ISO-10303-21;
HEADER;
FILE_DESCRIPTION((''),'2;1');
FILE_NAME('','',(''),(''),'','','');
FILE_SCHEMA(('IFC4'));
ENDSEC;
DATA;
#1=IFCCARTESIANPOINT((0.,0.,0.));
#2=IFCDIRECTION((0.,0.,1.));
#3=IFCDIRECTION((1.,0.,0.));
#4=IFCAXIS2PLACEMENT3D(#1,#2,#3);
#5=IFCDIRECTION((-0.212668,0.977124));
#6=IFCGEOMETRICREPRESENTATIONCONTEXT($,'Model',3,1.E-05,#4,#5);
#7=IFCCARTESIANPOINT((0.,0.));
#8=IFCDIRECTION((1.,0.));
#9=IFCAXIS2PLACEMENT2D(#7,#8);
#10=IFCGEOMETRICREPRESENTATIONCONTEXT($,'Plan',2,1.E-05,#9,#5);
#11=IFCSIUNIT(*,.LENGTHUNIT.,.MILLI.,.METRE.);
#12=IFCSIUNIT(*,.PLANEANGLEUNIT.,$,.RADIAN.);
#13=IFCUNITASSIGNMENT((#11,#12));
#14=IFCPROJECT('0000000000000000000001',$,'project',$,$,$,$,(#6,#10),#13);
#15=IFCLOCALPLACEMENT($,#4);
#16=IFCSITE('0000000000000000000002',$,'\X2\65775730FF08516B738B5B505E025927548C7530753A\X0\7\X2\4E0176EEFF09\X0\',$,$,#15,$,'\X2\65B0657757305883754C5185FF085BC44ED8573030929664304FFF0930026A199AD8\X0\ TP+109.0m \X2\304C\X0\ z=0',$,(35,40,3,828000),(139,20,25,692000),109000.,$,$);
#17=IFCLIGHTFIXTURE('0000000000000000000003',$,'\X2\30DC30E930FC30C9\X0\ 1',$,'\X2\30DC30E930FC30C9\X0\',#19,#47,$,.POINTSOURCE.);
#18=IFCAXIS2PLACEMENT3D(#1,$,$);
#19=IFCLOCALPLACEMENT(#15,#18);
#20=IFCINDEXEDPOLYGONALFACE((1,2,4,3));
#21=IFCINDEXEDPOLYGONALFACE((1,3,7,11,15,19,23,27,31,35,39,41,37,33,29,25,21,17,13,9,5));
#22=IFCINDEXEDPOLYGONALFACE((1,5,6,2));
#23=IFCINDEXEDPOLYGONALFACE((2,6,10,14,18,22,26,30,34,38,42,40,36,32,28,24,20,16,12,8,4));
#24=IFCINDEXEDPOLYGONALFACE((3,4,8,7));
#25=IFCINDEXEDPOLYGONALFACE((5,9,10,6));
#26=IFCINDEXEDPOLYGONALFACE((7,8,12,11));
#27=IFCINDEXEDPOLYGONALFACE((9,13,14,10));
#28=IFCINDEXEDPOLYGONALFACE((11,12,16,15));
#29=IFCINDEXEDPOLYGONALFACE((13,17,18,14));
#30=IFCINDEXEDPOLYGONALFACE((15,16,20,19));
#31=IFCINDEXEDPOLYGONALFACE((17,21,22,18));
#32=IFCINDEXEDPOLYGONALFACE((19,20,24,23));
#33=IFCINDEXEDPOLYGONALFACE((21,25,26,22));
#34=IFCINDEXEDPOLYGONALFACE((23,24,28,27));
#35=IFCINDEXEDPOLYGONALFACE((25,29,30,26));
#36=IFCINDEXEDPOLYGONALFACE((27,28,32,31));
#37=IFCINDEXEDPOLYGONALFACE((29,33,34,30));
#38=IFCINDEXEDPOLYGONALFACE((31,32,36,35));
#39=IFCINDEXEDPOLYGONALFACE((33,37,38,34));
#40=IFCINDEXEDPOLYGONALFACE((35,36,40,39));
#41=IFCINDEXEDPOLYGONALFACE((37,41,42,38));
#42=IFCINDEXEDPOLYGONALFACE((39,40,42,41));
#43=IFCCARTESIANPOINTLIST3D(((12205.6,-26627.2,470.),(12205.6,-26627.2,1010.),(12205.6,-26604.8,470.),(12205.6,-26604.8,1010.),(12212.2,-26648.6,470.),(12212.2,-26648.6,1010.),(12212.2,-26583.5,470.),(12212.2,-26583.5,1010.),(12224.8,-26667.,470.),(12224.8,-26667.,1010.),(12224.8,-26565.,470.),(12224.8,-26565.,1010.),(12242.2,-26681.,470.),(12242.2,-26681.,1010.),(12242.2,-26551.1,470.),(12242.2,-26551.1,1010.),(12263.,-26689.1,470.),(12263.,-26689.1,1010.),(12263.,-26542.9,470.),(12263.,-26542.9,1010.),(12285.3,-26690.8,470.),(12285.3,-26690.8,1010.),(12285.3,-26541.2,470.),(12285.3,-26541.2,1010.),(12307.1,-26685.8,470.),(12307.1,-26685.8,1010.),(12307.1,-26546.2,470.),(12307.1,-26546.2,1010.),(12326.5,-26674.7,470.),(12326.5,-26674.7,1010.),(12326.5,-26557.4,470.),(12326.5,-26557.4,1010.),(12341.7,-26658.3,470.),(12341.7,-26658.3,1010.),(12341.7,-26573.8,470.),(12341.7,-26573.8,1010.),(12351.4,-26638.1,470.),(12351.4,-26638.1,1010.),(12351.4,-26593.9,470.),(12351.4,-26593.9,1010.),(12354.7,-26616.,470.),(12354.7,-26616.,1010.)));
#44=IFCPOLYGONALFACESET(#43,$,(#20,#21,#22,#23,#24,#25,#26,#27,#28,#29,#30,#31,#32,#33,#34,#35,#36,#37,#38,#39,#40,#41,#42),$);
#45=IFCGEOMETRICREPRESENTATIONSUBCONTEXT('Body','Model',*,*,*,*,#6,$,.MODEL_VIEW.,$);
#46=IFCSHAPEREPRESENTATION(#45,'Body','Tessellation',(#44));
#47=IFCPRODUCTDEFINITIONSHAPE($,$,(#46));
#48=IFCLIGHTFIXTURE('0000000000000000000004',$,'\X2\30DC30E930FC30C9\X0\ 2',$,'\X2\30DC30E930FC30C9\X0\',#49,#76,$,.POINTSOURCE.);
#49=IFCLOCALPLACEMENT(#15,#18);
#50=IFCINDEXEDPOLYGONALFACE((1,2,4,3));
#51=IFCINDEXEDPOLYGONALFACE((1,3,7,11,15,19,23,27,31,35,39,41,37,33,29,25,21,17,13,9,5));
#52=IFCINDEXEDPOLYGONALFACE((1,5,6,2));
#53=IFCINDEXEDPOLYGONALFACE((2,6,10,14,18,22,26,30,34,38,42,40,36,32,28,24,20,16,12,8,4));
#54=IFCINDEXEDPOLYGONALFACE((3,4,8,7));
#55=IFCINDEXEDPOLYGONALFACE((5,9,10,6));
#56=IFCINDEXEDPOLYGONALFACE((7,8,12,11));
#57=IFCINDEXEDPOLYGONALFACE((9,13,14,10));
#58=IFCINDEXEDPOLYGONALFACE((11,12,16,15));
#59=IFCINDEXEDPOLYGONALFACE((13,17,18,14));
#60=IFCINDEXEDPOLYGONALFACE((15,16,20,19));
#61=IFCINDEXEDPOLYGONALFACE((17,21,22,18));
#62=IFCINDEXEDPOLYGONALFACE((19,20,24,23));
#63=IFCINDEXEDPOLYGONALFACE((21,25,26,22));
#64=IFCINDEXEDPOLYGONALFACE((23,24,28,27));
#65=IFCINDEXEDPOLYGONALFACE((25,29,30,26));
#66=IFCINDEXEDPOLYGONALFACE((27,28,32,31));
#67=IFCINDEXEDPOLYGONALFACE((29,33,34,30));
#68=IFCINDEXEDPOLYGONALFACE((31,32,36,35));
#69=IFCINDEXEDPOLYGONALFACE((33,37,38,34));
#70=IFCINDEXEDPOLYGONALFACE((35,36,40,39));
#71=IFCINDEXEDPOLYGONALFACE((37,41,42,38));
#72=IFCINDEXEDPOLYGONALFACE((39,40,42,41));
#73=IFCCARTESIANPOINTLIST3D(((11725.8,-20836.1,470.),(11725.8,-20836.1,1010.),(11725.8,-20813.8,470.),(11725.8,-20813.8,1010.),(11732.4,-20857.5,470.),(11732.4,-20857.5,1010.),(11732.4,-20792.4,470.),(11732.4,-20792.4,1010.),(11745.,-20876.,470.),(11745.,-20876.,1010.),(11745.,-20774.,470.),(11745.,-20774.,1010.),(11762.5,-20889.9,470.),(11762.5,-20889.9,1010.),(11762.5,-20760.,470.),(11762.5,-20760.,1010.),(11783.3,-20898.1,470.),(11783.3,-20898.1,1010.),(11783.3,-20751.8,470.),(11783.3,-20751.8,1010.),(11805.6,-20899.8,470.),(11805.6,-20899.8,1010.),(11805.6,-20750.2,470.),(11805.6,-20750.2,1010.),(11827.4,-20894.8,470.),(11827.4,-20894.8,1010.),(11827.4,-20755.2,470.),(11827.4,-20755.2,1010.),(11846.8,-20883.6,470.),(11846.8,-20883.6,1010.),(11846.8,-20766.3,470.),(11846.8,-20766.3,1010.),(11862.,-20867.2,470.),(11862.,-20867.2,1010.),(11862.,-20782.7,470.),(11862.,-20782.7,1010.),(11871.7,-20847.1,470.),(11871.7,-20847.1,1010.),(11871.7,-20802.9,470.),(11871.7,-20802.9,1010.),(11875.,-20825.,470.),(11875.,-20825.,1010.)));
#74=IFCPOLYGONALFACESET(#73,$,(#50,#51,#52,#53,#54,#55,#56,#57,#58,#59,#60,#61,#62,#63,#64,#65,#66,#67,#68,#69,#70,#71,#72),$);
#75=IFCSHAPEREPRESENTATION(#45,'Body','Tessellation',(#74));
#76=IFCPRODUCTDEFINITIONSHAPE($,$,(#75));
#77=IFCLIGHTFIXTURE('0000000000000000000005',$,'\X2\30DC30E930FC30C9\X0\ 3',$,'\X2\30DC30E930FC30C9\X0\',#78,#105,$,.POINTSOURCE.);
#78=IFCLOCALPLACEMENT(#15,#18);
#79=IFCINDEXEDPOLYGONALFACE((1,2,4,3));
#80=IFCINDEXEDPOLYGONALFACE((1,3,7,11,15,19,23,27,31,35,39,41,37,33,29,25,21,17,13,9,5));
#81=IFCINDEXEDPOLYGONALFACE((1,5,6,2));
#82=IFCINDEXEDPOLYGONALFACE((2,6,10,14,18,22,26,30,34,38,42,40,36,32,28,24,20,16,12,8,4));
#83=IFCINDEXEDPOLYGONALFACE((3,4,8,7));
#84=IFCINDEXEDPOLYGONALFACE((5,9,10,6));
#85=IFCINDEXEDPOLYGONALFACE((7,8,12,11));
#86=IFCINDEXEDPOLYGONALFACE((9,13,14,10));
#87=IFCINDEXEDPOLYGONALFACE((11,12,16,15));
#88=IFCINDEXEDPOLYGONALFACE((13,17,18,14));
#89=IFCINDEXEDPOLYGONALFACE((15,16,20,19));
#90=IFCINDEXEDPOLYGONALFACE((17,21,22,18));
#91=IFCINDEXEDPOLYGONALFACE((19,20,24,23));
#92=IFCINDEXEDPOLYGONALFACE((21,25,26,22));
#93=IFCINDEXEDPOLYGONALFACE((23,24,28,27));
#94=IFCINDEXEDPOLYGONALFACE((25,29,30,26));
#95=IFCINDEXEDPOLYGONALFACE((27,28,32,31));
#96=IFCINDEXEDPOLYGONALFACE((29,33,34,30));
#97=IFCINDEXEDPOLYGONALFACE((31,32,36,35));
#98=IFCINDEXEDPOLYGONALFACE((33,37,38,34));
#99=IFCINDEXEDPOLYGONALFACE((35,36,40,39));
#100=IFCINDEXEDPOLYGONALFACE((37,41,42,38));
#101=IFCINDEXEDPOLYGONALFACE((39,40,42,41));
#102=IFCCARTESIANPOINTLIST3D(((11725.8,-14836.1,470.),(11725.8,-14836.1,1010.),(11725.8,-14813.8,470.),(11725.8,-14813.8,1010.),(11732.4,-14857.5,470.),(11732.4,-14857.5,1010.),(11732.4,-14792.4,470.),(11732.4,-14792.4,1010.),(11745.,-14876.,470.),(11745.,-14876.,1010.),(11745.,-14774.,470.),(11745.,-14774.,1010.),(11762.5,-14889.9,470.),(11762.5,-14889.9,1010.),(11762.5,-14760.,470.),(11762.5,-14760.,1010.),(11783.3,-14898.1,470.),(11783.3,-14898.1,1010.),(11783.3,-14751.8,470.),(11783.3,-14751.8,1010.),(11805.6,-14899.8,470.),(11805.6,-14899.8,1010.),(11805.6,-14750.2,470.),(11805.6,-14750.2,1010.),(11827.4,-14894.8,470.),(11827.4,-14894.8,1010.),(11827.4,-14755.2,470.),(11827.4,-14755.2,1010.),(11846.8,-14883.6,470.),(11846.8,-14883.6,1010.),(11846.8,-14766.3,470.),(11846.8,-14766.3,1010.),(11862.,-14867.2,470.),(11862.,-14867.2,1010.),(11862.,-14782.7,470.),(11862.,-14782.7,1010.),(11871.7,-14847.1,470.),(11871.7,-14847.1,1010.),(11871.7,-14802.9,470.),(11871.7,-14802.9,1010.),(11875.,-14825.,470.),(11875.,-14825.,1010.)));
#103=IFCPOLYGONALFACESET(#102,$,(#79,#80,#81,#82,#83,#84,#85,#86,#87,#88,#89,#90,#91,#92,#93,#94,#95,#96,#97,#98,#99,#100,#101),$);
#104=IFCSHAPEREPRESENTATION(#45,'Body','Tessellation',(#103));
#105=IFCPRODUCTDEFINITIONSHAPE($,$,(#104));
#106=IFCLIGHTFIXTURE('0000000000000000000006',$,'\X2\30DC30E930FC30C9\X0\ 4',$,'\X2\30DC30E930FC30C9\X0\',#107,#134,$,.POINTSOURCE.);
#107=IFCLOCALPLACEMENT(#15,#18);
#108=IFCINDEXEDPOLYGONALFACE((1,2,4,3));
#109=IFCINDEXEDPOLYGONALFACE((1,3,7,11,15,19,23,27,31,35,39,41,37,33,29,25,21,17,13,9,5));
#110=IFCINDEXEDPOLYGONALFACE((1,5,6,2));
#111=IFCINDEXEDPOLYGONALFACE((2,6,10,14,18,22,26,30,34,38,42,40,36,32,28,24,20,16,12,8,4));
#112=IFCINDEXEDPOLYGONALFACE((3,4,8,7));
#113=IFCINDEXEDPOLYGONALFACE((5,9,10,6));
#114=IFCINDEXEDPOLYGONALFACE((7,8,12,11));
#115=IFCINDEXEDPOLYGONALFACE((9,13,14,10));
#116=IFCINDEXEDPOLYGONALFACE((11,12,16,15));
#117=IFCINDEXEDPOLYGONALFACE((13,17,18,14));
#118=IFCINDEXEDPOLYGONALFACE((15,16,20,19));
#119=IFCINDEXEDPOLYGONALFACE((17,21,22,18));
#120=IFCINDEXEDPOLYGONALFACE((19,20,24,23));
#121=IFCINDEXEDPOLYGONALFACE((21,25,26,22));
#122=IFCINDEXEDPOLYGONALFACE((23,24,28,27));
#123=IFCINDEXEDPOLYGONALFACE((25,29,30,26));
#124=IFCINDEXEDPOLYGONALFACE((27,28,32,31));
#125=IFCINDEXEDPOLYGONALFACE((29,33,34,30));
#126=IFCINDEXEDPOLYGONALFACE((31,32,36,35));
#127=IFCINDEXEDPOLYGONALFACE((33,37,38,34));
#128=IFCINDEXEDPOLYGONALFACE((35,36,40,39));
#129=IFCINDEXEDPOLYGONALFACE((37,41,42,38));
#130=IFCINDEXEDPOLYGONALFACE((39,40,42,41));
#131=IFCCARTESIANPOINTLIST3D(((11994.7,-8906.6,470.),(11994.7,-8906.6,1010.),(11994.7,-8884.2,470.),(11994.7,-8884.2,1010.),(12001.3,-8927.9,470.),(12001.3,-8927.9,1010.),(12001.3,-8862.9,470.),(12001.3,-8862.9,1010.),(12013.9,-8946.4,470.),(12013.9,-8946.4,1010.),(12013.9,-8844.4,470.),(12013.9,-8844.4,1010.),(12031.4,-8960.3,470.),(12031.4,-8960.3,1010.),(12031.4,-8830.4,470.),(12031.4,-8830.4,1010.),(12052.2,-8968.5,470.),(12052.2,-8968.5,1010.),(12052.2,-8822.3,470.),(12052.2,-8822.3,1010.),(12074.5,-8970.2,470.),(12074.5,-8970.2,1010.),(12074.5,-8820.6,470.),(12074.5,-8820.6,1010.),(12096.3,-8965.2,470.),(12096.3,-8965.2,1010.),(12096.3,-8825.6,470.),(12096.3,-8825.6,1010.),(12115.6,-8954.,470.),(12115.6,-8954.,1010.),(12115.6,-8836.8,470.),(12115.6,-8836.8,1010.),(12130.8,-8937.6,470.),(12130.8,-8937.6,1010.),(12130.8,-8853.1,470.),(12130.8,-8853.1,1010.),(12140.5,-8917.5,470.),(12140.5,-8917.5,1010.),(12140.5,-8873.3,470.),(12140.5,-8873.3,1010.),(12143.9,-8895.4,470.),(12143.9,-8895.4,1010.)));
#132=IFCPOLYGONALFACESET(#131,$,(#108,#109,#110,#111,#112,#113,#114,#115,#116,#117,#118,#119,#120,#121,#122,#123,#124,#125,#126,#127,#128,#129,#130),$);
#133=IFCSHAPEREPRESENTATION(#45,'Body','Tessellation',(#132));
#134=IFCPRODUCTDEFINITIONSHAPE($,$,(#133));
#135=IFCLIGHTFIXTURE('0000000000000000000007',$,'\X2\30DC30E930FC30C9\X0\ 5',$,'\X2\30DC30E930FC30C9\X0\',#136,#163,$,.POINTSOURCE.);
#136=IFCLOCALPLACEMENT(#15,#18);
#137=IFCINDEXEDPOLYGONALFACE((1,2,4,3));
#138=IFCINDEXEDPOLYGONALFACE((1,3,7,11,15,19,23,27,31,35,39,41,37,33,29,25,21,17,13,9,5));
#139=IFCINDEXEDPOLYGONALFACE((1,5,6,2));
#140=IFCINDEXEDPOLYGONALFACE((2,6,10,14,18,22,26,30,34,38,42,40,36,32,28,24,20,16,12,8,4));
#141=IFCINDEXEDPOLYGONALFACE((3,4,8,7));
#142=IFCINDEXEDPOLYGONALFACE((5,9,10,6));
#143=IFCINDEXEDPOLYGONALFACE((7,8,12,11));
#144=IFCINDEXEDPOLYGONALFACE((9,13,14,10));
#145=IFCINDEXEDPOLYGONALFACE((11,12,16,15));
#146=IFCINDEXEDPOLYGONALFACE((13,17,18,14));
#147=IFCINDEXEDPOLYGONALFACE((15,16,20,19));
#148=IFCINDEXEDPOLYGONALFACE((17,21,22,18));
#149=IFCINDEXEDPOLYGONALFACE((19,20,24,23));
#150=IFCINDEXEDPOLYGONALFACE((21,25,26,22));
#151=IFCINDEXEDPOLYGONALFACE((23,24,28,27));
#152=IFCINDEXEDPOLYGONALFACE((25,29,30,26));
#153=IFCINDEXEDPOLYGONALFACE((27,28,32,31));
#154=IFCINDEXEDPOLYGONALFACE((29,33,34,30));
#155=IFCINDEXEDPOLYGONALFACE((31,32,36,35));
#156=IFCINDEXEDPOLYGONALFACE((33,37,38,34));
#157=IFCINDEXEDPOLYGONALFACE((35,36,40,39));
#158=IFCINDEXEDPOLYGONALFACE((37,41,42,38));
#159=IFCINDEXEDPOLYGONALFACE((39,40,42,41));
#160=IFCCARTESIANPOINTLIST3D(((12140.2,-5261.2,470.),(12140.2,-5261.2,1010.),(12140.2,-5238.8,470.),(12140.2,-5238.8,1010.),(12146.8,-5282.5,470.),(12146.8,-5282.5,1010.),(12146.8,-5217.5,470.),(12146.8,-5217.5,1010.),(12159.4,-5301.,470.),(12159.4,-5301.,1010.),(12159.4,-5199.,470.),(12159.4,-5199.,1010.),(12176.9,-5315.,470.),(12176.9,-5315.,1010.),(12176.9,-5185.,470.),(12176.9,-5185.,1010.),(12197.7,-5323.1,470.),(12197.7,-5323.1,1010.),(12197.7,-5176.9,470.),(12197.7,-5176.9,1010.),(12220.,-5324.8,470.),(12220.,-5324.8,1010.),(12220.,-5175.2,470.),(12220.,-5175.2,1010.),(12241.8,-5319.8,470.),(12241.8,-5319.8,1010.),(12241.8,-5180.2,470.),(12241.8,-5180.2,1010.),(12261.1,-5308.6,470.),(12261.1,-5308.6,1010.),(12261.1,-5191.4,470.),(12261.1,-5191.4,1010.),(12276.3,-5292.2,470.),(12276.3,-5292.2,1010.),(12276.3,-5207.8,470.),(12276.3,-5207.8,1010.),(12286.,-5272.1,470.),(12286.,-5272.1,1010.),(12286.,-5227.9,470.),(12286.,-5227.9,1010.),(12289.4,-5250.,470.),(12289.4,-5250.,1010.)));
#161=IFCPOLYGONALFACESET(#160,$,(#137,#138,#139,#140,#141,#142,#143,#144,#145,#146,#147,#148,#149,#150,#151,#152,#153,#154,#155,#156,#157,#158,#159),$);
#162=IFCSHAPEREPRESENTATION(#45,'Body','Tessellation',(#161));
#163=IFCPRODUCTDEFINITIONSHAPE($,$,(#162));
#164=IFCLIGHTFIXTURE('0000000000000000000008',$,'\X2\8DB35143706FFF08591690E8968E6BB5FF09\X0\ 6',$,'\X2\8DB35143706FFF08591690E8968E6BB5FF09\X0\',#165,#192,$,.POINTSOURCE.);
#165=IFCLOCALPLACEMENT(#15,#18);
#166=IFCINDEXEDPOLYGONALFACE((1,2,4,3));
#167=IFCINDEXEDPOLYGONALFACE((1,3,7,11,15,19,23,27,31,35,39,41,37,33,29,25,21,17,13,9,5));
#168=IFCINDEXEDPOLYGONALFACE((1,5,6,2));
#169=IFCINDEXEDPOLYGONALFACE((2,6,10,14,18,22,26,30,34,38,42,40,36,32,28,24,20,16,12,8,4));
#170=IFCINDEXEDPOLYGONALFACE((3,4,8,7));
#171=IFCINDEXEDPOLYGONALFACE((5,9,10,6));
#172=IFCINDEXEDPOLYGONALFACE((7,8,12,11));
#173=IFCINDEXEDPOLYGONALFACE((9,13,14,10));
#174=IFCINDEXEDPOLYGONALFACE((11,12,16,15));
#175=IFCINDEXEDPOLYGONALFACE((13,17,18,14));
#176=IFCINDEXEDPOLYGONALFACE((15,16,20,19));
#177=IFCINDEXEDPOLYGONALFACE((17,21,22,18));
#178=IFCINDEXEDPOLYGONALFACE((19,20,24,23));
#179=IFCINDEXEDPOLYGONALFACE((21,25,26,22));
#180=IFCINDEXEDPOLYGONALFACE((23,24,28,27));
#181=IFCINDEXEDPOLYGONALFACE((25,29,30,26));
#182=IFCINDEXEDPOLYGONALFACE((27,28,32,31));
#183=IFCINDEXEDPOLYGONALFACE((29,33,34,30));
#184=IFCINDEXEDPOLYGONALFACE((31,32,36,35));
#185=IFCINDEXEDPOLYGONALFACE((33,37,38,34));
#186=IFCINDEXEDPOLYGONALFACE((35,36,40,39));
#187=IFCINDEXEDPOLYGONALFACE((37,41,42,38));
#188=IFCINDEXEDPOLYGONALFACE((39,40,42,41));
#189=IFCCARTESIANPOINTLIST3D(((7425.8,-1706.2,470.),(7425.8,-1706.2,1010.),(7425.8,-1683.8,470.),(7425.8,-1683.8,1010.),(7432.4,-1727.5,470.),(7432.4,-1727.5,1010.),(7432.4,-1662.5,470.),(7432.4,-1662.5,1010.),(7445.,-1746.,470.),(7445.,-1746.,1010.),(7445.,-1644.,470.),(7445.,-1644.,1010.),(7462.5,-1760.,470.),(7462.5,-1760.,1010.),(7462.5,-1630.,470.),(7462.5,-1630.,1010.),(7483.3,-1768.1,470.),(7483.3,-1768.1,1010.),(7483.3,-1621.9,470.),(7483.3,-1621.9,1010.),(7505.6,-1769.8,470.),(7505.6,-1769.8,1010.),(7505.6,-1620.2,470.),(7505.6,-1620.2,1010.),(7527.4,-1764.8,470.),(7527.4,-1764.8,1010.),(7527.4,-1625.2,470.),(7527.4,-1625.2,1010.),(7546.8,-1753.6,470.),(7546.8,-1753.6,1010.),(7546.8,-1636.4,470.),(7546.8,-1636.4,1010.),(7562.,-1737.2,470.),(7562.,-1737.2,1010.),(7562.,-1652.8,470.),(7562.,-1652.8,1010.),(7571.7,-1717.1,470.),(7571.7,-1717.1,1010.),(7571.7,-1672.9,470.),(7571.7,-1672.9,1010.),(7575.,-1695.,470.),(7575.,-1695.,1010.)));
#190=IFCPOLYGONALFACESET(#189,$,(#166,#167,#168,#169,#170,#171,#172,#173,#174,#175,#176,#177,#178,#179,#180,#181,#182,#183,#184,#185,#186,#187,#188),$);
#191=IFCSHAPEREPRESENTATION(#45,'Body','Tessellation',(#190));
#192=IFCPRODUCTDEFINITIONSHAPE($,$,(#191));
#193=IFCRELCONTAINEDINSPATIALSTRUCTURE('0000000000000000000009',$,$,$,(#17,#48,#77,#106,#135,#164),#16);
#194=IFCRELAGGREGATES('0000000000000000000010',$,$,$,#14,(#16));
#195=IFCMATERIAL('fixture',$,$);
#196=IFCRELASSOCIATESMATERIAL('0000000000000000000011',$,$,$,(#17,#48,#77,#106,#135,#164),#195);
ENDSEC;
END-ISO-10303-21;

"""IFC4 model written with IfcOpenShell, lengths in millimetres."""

from ifc_helpers import new_model, si_unit, direction, frame, frame_2d, origin_with_axes, origin_2d_with_axis, place, context, subcontext, project, spatial, circle, extrude, material, element, save


model = new_model("IFC4")

# Units and contexts
model_context = context("Model", 3, precision=1e-05, world=origin_with_axes(), true_north=direction((-0.212668, 0.977124)))
plan_context = context("Plan", 2, precision=1e-05, world=origin_2d_with_axis(), true_north=direction((-0.212668, 0.977124)))
body_context = subcontext(model_context, "Body", "Model", "MODEL_VIEW")
ifc_project = project(units=[si_unit("LENGTHUNIT", "METRE", prefix="MILLI"), si_unit("PLANEANGLEUNIT", "RADIAN")], contexts=[model_context, plan_context])

# Site
site_placement = place(None, origin_with_axes())
site = spatial("IfcSite", under=ifc_project, at=site_placement, Name="敷地（八王子市大和田町7丁目）", LongName="新敷地境界内（寄付地を除く）。標高 TP+109.0m が z=0", RefLatitude=(35, 40, 3, 828000), RefLongitude=(139, 20, 25, 692000), RefElevation=109000.0)

# Light fixtures
ifc_material_1 = material(Name="fixture")
light_fixture_1_placement = place(site_placement, origin_with_axes())
element("IfcLightFixture", 1, at=light_fixture_1_placement, inside=site, material=ifc_material_1, Name="ボラード 1", ObjectType="ボラード", PredefinedType="POINTSOURCE", context=body_context, shape_type="SweptSolid", body=[
    extrude(circle(Radius=75.0, at=frame_2d((12279.7, -26616.0))), frame((0.0, 0.0, 470.0)), (0.0, 0.0, 1.0), 540.0),
])
light_fixture_2_placement = place(site_placement, origin_with_axes())
element("IfcLightFixture", 2, at=light_fixture_2_placement, inside=site, material=ifc_material_1, Name="ボラード 2", ObjectType="ボラード", PredefinedType="POINTSOURCE", context=body_context, shape_type="SweptSolid", body=[
    extrude(circle(Radius=75.0, at=frame_2d((11800.0, -20825.0))), frame((0.0, 0.0, 470.0)), (0.0, 0.0, 1.0), 540.0),
])
light_fixture_3_placement = place(site_placement, origin_with_axes())
element("IfcLightFixture", 3, at=light_fixture_3_placement, inside=site, material=ifc_material_1, Name="ボラード 3", ObjectType="ボラード", PredefinedType="POINTSOURCE", context=body_context, shape_type="SweptSolid", body=[
    extrude(circle(Radius=75.0, at=frame_2d((11800.0, -14825.0))), frame((0.0, 0.0, 470.0)), (0.0, 0.0, 1.0), 540.0),
])
light_fixture_4_placement = place(site_placement, origin_with_axes())
element("IfcLightFixture", 4, at=light_fixture_4_placement, inside=site, material=ifc_material_1, Name="ボラード 4", ObjectType="ボラード", PredefinedType="POINTSOURCE", context=body_context, shape_type="SweptSolid", body=[
    extrude(circle(Radius=75.0, at=frame_2d((12068.9, -8895.4))), frame((0.0, 0.0, 470.0)), (0.0, 0.0, 1.0), 540.0),
])
light_fixture_5_placement = place(site_placement, origin_with_axes())
element("IfcLightFixture", 5, at=light_fixture_5_placement, inside=site, material=ifc_material_1, Name="ボラード 5", ObjectType="ボラード", PredefinedType="POINTSOURCE", context=body_context, shape_type="SweptSolid", body=[
    extrude(circle(Radius=75.0, at=frame_2d((12214.4, -5250.0))), frame((0.0, 0.0, 470.0)), (0.0, 0.0, 1.0), 540.0),
])
light_fixture_6_placement = place(site_placement, origin_with_axes())
element("IfcLightFixture", 6, at=light_fixture_6_placement, inside=site, material=ifc_material_1, Name="足元灯（外部階段） 6", ObjectType="足元灯（外部階段）", PredefinedType="POINTSOURCE", context=body_context, shape_type="SweptSolid", body=[
    extrude(circle(Radius=75.0, at=frame_2d((7500.0, -1695.0))), frame((0.0, 0.0, 470.0)), (0.0, 0.0, 1.0), 540.0),
])

save(model, "model.ifc")
